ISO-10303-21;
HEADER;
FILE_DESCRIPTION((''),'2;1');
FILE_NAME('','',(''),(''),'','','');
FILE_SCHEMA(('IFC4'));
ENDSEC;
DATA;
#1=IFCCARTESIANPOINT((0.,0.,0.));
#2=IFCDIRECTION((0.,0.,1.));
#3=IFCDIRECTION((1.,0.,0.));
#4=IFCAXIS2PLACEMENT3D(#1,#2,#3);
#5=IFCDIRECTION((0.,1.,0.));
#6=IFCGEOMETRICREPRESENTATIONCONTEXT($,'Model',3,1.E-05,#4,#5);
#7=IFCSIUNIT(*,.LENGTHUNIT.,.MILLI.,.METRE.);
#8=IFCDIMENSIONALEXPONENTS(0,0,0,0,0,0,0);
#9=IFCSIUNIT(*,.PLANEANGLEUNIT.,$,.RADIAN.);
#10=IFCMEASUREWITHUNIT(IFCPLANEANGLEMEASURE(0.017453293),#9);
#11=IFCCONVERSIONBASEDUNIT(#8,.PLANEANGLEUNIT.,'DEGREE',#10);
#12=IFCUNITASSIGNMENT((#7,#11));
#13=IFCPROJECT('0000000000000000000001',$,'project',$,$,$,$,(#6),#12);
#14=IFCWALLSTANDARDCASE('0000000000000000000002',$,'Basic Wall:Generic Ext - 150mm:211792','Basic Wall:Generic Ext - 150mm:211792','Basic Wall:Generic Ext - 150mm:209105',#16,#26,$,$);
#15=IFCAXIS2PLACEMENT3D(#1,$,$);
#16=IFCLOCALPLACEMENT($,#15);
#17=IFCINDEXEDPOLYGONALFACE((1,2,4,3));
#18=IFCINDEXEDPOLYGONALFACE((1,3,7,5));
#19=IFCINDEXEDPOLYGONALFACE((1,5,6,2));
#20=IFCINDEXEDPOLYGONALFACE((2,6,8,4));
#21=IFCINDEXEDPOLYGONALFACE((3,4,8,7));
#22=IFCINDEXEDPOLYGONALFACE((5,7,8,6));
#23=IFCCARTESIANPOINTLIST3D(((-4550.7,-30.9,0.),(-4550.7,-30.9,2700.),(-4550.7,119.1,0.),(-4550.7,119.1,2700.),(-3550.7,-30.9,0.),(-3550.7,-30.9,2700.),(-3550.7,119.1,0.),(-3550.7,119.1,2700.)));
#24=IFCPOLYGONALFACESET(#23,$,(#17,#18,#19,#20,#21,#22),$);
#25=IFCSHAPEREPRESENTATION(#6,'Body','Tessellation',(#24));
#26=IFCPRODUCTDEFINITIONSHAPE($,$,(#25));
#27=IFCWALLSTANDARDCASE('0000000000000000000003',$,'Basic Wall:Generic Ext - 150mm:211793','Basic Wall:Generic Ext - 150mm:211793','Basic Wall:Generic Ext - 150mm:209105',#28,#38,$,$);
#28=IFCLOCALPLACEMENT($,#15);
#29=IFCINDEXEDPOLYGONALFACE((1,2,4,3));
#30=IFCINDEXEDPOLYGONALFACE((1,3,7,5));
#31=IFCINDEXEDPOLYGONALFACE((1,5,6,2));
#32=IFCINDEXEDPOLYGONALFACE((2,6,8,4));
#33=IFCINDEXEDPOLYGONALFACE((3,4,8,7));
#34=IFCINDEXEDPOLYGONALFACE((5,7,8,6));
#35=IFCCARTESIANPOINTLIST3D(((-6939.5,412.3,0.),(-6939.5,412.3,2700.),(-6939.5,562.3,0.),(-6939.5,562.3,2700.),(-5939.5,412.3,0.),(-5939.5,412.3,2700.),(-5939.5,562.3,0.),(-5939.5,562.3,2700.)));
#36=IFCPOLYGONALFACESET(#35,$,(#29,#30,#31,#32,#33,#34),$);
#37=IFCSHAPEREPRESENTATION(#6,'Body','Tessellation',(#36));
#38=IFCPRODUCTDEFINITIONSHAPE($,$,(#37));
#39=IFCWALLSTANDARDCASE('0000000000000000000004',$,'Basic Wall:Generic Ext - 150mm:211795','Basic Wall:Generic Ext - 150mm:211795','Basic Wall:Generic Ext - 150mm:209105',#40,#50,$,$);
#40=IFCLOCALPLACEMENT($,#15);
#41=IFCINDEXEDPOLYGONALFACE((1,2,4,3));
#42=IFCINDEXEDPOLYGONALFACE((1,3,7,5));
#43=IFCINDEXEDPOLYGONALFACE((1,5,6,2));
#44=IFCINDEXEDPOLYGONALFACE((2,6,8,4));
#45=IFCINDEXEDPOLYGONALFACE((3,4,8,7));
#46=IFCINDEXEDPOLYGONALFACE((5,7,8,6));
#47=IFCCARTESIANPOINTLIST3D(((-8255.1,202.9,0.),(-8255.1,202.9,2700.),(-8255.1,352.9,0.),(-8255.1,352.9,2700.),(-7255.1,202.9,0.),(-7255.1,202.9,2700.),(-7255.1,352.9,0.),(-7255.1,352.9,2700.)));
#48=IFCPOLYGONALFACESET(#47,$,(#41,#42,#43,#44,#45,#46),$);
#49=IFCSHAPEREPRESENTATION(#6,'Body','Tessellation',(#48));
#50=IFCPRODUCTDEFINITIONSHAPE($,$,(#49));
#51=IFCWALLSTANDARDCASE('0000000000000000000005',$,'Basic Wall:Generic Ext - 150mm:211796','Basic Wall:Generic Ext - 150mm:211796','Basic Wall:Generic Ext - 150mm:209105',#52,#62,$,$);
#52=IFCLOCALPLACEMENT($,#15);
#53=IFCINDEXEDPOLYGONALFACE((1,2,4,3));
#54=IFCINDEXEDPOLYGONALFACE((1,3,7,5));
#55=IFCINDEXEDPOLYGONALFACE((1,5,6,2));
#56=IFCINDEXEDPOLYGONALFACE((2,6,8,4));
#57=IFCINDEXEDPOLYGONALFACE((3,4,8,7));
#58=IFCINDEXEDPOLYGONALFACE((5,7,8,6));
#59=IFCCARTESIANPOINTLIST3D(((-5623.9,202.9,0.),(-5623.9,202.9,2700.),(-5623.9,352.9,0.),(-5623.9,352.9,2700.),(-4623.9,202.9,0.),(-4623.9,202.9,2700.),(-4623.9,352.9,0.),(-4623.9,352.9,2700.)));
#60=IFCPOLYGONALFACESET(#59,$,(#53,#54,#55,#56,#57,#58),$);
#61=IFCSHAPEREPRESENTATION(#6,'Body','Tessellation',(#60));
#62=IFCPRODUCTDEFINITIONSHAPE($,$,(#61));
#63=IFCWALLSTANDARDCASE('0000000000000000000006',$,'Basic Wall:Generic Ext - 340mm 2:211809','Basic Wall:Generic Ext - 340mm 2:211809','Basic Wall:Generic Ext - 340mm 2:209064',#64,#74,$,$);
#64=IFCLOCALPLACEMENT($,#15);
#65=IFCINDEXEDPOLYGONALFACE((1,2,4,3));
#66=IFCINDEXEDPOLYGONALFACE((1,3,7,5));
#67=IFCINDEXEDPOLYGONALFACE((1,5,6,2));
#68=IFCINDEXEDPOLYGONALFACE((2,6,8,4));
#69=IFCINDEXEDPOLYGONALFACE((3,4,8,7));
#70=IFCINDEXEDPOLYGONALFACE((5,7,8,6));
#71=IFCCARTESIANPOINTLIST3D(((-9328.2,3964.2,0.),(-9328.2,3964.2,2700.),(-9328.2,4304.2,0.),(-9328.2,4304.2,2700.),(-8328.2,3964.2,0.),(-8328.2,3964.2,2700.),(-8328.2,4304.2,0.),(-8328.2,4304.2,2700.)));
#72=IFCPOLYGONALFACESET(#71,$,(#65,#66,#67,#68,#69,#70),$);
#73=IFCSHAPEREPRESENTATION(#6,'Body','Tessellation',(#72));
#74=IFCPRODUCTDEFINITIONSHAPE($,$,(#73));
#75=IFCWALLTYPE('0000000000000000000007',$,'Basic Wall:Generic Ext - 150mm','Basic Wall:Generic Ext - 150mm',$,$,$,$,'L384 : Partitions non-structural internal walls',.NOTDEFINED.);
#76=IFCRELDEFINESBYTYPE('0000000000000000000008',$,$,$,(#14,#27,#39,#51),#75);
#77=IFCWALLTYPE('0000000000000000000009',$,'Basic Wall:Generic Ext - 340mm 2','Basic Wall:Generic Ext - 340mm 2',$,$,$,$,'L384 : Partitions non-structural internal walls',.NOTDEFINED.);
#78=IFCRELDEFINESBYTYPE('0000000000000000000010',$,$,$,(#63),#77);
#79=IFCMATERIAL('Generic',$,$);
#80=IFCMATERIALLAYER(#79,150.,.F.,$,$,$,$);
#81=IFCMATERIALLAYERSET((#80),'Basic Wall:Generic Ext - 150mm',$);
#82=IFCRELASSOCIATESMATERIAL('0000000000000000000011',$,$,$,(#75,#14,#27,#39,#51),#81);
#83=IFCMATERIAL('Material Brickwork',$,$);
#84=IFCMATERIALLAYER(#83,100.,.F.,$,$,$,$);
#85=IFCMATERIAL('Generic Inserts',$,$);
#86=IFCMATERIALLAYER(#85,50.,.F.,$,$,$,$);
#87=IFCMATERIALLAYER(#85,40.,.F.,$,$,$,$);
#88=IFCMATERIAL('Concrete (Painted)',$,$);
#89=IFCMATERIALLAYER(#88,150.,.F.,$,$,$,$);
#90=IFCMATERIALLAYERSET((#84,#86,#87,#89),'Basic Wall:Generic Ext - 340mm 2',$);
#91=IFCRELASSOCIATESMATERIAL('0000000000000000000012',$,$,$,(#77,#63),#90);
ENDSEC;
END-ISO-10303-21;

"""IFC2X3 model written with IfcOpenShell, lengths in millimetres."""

from ifc_helpers import new_model, entity, si_unit, converted_unit, direction, frame, frame_2d, origin, origin_with_axes, place, context, project, rectangle, extrude, source, transform, mapped, material, layer, layer_set, layer_usage, type_object, type_shapes, element, save


model = new_model("IFC2X3")

# Units and contexts
model_context = context("Model", 3, precision=1e-05, world=origin_with_axes(), true_north=direction((0.0, 1.0, 0.0)))
ifc_project = project(units=[si_unit("LENGTHUNIT", "METRE", prefix="MILLI"), converted_unit("PLANEANGLEUNIT", "DEGREE", entity("IfcPlaneAngleMeasure", 0.017453293), si_unit("PLANEANGLEUNIT", "RADIAN"), dimensions=[0, 0, 0, 0, 0, 0, 0])], contexts=[model_context])

# Walls
ifc_material_1 = material(Name="Generic")
ifc_layer_1 = layer(ifc_material_1, 150.0, ventilated=False)
ifc_layer_set_1 = layer_set([ifc_layer_1], Name="Basic Wall:Generic Ext - 150mm")
ifc_layer_usage_1 = layer_usage(ifc_layer_set_1, "AXIS3", "POSITIVE", 0.0)
wall_type_1 = type_object("IfcWallType", Name="Basic Wall:Generic Ext - 150mm", Description="Basic Wall:Generic Ext - 150mm", ElementType="L384 : Partitions non-structural internal walls", PredefinedType="NOTDEFINED", material=ifc_layer_set_1)
shared_shape_1 = source(origin(), model_context, "Body", "SweptSolid", [
    extrude(rectangle(XDim=1000.0, YDim=150.0, at=frame_2d((500.0, 75.0), x_axis=(1.0, 0.0))), origin_with_axes(), (0.0, 0.0, 1.0), 2700.0),
])
type_shapes(wall_type_1, [shared_shape_1])
placement_1 = place(None, origin_with_axes())
placement_2 = place(placement_1, origin_with_axes())
placement_3 = place(placement_2, origin_with_axes())
placement_4 = place(placement_3, origin_with_axes())
for number, where, z_axis, x_axis, name, description in (
    (1, (-4550.7, -30.9, 0.0), (0.0, 0.0, 1.0), (1.0, 0.0, 0.0), "Basic Wall:Generic Ext - 150mm:211792", "Basic Wall:Generic Ext - 150mm:211792"),
    (2, (-6939.5, 412.3, 0.0), (0.0, 0.0, 1.0), (1.0, 0.0, 0.0), "Basic Wall:Generic Ext - 150mm:211793", "Basic Wall:Generic Ext - 150mm:211793"),
    (3, (-8255.1, 202.9, 0.0), (0.0, 0.0, 1.0), (1.0, 0.0, 0.0), "Basic Wall:Generic Ext - 150mm:211795", "Basic Wall:Generic Ext - 150mm:211795"),
):
    element("IfcWallStandardCase", number, at=place(placement_4, frame(where, z_axis=z_axis, x_axis=x_axis)), type_object=wall_type_1, material=ifc_layer_usage_1, Name=name, Description=description, ObjectType="Basic Wall:Generic Ext - 150mm:209105", context=model_context, shape_type="MappedRepresentation", body=[
        mapped(shared_shape_1, transform((0.0, 0.0, 0.0))),
    ])
placement_5 = place(placement_3, origin_with_axes())
wall_1_placement = place(placement_5, frame((-5623.9, 202.9, 0.0), z_axis=(0.0, 0.0, 1.0), x_axis=(1.0, 0.0, 0.0)))
element("IfcWallStandardCase", 4, at=wall_1_placement, type_object=wall_type_1, material=ifc_layer_usage_1, Name="Basic Wall:Generic Ext - 150mm:211796", Description="Basic Wall:Generic Ext - 150mm:211796", ObjectType="Basic Wall:Generic Ext - 150mm:209105", context=model_context, shape_type="MappedRepresentation", body=[
    mapped(shared_shape_1, transform((0.0, 0.0, 0.0))),
])
ifc_material_2 = material(Name="Material Brickwork")
ifc_layer_2 = layer(ifc_material_2, 100.0, ventilated=False)
ifc_material_3 = material(Name="Generic Inserts")
ifc_layer_3 = layer(ifc_material_3, 50.0, ventilated=False)
ifc_layer_4 = layer(ifc_material_3, 40.0, ventilated=False)
ifc_material_4 = material(Name="Concrete (Painted)")
ifc_layer_5 = layer(ifc_material_4, 150.0, ventilated=False)
ifc_layer_set_2 = layer_set([ifc_layer_2, ifc_layer_3, ifc_layer_4, ifc_layer_5], Name="Basic Wall:Generic Ext - 340mm 2")
ifc_layer_usage_2 = layer_usage(ifc_layer_set_2, "AXIS3", "POSITIVE", 0.0)
wall_type_2 = type_object("IfcWallType", Name="Basic Wall:Generic Ext - 340mm 2", Description="Basic Wall:Generic Ext - 340mm 2", ElementType="L384 : Partitions non-structural internal walls", PredefinedType="NOTDEFINED", material=ifc_layer_set_2)
shared_shape_2 = source(origin(), model_context, "Body", "SweptSolid", [
    extrude(rectangle(XDim=1000.0, YDim=340.0, at=frame_2d((500.0, 170.0), x_axis=(1.0, 0.0))), origin_with_axes(), (0.0, 0.0, 1.0), 2700.0),
])
type_shapes(wall_type_2, [shared_shape_2])
wall_2_placement = place(placement_4, frame((-9328.2, 3964.2, 0.0), z_axis=(0.0, 0.0, 1.0), x_axis=(1.0, 0.0, 0.0)))
element("IfcWallStandardCase", 5, at=wall_2_placement, type_object=wall_type_2, material=ifc_layer_usage_2, Name="Basic Wall:Generic Ext - 340mm 2:211809", Description="Basic Wall:Generic Ext - 340mm 2:211809", ObjectType="Basic Wall:Generic Ext - 340mm 2:209064", context=model_context, shape_type="MappedRepresentation", body=[
    mapped(shared_shape_2, transform((0.0, 0.0, 0.0))),
])

save(model, "model.ifc")
